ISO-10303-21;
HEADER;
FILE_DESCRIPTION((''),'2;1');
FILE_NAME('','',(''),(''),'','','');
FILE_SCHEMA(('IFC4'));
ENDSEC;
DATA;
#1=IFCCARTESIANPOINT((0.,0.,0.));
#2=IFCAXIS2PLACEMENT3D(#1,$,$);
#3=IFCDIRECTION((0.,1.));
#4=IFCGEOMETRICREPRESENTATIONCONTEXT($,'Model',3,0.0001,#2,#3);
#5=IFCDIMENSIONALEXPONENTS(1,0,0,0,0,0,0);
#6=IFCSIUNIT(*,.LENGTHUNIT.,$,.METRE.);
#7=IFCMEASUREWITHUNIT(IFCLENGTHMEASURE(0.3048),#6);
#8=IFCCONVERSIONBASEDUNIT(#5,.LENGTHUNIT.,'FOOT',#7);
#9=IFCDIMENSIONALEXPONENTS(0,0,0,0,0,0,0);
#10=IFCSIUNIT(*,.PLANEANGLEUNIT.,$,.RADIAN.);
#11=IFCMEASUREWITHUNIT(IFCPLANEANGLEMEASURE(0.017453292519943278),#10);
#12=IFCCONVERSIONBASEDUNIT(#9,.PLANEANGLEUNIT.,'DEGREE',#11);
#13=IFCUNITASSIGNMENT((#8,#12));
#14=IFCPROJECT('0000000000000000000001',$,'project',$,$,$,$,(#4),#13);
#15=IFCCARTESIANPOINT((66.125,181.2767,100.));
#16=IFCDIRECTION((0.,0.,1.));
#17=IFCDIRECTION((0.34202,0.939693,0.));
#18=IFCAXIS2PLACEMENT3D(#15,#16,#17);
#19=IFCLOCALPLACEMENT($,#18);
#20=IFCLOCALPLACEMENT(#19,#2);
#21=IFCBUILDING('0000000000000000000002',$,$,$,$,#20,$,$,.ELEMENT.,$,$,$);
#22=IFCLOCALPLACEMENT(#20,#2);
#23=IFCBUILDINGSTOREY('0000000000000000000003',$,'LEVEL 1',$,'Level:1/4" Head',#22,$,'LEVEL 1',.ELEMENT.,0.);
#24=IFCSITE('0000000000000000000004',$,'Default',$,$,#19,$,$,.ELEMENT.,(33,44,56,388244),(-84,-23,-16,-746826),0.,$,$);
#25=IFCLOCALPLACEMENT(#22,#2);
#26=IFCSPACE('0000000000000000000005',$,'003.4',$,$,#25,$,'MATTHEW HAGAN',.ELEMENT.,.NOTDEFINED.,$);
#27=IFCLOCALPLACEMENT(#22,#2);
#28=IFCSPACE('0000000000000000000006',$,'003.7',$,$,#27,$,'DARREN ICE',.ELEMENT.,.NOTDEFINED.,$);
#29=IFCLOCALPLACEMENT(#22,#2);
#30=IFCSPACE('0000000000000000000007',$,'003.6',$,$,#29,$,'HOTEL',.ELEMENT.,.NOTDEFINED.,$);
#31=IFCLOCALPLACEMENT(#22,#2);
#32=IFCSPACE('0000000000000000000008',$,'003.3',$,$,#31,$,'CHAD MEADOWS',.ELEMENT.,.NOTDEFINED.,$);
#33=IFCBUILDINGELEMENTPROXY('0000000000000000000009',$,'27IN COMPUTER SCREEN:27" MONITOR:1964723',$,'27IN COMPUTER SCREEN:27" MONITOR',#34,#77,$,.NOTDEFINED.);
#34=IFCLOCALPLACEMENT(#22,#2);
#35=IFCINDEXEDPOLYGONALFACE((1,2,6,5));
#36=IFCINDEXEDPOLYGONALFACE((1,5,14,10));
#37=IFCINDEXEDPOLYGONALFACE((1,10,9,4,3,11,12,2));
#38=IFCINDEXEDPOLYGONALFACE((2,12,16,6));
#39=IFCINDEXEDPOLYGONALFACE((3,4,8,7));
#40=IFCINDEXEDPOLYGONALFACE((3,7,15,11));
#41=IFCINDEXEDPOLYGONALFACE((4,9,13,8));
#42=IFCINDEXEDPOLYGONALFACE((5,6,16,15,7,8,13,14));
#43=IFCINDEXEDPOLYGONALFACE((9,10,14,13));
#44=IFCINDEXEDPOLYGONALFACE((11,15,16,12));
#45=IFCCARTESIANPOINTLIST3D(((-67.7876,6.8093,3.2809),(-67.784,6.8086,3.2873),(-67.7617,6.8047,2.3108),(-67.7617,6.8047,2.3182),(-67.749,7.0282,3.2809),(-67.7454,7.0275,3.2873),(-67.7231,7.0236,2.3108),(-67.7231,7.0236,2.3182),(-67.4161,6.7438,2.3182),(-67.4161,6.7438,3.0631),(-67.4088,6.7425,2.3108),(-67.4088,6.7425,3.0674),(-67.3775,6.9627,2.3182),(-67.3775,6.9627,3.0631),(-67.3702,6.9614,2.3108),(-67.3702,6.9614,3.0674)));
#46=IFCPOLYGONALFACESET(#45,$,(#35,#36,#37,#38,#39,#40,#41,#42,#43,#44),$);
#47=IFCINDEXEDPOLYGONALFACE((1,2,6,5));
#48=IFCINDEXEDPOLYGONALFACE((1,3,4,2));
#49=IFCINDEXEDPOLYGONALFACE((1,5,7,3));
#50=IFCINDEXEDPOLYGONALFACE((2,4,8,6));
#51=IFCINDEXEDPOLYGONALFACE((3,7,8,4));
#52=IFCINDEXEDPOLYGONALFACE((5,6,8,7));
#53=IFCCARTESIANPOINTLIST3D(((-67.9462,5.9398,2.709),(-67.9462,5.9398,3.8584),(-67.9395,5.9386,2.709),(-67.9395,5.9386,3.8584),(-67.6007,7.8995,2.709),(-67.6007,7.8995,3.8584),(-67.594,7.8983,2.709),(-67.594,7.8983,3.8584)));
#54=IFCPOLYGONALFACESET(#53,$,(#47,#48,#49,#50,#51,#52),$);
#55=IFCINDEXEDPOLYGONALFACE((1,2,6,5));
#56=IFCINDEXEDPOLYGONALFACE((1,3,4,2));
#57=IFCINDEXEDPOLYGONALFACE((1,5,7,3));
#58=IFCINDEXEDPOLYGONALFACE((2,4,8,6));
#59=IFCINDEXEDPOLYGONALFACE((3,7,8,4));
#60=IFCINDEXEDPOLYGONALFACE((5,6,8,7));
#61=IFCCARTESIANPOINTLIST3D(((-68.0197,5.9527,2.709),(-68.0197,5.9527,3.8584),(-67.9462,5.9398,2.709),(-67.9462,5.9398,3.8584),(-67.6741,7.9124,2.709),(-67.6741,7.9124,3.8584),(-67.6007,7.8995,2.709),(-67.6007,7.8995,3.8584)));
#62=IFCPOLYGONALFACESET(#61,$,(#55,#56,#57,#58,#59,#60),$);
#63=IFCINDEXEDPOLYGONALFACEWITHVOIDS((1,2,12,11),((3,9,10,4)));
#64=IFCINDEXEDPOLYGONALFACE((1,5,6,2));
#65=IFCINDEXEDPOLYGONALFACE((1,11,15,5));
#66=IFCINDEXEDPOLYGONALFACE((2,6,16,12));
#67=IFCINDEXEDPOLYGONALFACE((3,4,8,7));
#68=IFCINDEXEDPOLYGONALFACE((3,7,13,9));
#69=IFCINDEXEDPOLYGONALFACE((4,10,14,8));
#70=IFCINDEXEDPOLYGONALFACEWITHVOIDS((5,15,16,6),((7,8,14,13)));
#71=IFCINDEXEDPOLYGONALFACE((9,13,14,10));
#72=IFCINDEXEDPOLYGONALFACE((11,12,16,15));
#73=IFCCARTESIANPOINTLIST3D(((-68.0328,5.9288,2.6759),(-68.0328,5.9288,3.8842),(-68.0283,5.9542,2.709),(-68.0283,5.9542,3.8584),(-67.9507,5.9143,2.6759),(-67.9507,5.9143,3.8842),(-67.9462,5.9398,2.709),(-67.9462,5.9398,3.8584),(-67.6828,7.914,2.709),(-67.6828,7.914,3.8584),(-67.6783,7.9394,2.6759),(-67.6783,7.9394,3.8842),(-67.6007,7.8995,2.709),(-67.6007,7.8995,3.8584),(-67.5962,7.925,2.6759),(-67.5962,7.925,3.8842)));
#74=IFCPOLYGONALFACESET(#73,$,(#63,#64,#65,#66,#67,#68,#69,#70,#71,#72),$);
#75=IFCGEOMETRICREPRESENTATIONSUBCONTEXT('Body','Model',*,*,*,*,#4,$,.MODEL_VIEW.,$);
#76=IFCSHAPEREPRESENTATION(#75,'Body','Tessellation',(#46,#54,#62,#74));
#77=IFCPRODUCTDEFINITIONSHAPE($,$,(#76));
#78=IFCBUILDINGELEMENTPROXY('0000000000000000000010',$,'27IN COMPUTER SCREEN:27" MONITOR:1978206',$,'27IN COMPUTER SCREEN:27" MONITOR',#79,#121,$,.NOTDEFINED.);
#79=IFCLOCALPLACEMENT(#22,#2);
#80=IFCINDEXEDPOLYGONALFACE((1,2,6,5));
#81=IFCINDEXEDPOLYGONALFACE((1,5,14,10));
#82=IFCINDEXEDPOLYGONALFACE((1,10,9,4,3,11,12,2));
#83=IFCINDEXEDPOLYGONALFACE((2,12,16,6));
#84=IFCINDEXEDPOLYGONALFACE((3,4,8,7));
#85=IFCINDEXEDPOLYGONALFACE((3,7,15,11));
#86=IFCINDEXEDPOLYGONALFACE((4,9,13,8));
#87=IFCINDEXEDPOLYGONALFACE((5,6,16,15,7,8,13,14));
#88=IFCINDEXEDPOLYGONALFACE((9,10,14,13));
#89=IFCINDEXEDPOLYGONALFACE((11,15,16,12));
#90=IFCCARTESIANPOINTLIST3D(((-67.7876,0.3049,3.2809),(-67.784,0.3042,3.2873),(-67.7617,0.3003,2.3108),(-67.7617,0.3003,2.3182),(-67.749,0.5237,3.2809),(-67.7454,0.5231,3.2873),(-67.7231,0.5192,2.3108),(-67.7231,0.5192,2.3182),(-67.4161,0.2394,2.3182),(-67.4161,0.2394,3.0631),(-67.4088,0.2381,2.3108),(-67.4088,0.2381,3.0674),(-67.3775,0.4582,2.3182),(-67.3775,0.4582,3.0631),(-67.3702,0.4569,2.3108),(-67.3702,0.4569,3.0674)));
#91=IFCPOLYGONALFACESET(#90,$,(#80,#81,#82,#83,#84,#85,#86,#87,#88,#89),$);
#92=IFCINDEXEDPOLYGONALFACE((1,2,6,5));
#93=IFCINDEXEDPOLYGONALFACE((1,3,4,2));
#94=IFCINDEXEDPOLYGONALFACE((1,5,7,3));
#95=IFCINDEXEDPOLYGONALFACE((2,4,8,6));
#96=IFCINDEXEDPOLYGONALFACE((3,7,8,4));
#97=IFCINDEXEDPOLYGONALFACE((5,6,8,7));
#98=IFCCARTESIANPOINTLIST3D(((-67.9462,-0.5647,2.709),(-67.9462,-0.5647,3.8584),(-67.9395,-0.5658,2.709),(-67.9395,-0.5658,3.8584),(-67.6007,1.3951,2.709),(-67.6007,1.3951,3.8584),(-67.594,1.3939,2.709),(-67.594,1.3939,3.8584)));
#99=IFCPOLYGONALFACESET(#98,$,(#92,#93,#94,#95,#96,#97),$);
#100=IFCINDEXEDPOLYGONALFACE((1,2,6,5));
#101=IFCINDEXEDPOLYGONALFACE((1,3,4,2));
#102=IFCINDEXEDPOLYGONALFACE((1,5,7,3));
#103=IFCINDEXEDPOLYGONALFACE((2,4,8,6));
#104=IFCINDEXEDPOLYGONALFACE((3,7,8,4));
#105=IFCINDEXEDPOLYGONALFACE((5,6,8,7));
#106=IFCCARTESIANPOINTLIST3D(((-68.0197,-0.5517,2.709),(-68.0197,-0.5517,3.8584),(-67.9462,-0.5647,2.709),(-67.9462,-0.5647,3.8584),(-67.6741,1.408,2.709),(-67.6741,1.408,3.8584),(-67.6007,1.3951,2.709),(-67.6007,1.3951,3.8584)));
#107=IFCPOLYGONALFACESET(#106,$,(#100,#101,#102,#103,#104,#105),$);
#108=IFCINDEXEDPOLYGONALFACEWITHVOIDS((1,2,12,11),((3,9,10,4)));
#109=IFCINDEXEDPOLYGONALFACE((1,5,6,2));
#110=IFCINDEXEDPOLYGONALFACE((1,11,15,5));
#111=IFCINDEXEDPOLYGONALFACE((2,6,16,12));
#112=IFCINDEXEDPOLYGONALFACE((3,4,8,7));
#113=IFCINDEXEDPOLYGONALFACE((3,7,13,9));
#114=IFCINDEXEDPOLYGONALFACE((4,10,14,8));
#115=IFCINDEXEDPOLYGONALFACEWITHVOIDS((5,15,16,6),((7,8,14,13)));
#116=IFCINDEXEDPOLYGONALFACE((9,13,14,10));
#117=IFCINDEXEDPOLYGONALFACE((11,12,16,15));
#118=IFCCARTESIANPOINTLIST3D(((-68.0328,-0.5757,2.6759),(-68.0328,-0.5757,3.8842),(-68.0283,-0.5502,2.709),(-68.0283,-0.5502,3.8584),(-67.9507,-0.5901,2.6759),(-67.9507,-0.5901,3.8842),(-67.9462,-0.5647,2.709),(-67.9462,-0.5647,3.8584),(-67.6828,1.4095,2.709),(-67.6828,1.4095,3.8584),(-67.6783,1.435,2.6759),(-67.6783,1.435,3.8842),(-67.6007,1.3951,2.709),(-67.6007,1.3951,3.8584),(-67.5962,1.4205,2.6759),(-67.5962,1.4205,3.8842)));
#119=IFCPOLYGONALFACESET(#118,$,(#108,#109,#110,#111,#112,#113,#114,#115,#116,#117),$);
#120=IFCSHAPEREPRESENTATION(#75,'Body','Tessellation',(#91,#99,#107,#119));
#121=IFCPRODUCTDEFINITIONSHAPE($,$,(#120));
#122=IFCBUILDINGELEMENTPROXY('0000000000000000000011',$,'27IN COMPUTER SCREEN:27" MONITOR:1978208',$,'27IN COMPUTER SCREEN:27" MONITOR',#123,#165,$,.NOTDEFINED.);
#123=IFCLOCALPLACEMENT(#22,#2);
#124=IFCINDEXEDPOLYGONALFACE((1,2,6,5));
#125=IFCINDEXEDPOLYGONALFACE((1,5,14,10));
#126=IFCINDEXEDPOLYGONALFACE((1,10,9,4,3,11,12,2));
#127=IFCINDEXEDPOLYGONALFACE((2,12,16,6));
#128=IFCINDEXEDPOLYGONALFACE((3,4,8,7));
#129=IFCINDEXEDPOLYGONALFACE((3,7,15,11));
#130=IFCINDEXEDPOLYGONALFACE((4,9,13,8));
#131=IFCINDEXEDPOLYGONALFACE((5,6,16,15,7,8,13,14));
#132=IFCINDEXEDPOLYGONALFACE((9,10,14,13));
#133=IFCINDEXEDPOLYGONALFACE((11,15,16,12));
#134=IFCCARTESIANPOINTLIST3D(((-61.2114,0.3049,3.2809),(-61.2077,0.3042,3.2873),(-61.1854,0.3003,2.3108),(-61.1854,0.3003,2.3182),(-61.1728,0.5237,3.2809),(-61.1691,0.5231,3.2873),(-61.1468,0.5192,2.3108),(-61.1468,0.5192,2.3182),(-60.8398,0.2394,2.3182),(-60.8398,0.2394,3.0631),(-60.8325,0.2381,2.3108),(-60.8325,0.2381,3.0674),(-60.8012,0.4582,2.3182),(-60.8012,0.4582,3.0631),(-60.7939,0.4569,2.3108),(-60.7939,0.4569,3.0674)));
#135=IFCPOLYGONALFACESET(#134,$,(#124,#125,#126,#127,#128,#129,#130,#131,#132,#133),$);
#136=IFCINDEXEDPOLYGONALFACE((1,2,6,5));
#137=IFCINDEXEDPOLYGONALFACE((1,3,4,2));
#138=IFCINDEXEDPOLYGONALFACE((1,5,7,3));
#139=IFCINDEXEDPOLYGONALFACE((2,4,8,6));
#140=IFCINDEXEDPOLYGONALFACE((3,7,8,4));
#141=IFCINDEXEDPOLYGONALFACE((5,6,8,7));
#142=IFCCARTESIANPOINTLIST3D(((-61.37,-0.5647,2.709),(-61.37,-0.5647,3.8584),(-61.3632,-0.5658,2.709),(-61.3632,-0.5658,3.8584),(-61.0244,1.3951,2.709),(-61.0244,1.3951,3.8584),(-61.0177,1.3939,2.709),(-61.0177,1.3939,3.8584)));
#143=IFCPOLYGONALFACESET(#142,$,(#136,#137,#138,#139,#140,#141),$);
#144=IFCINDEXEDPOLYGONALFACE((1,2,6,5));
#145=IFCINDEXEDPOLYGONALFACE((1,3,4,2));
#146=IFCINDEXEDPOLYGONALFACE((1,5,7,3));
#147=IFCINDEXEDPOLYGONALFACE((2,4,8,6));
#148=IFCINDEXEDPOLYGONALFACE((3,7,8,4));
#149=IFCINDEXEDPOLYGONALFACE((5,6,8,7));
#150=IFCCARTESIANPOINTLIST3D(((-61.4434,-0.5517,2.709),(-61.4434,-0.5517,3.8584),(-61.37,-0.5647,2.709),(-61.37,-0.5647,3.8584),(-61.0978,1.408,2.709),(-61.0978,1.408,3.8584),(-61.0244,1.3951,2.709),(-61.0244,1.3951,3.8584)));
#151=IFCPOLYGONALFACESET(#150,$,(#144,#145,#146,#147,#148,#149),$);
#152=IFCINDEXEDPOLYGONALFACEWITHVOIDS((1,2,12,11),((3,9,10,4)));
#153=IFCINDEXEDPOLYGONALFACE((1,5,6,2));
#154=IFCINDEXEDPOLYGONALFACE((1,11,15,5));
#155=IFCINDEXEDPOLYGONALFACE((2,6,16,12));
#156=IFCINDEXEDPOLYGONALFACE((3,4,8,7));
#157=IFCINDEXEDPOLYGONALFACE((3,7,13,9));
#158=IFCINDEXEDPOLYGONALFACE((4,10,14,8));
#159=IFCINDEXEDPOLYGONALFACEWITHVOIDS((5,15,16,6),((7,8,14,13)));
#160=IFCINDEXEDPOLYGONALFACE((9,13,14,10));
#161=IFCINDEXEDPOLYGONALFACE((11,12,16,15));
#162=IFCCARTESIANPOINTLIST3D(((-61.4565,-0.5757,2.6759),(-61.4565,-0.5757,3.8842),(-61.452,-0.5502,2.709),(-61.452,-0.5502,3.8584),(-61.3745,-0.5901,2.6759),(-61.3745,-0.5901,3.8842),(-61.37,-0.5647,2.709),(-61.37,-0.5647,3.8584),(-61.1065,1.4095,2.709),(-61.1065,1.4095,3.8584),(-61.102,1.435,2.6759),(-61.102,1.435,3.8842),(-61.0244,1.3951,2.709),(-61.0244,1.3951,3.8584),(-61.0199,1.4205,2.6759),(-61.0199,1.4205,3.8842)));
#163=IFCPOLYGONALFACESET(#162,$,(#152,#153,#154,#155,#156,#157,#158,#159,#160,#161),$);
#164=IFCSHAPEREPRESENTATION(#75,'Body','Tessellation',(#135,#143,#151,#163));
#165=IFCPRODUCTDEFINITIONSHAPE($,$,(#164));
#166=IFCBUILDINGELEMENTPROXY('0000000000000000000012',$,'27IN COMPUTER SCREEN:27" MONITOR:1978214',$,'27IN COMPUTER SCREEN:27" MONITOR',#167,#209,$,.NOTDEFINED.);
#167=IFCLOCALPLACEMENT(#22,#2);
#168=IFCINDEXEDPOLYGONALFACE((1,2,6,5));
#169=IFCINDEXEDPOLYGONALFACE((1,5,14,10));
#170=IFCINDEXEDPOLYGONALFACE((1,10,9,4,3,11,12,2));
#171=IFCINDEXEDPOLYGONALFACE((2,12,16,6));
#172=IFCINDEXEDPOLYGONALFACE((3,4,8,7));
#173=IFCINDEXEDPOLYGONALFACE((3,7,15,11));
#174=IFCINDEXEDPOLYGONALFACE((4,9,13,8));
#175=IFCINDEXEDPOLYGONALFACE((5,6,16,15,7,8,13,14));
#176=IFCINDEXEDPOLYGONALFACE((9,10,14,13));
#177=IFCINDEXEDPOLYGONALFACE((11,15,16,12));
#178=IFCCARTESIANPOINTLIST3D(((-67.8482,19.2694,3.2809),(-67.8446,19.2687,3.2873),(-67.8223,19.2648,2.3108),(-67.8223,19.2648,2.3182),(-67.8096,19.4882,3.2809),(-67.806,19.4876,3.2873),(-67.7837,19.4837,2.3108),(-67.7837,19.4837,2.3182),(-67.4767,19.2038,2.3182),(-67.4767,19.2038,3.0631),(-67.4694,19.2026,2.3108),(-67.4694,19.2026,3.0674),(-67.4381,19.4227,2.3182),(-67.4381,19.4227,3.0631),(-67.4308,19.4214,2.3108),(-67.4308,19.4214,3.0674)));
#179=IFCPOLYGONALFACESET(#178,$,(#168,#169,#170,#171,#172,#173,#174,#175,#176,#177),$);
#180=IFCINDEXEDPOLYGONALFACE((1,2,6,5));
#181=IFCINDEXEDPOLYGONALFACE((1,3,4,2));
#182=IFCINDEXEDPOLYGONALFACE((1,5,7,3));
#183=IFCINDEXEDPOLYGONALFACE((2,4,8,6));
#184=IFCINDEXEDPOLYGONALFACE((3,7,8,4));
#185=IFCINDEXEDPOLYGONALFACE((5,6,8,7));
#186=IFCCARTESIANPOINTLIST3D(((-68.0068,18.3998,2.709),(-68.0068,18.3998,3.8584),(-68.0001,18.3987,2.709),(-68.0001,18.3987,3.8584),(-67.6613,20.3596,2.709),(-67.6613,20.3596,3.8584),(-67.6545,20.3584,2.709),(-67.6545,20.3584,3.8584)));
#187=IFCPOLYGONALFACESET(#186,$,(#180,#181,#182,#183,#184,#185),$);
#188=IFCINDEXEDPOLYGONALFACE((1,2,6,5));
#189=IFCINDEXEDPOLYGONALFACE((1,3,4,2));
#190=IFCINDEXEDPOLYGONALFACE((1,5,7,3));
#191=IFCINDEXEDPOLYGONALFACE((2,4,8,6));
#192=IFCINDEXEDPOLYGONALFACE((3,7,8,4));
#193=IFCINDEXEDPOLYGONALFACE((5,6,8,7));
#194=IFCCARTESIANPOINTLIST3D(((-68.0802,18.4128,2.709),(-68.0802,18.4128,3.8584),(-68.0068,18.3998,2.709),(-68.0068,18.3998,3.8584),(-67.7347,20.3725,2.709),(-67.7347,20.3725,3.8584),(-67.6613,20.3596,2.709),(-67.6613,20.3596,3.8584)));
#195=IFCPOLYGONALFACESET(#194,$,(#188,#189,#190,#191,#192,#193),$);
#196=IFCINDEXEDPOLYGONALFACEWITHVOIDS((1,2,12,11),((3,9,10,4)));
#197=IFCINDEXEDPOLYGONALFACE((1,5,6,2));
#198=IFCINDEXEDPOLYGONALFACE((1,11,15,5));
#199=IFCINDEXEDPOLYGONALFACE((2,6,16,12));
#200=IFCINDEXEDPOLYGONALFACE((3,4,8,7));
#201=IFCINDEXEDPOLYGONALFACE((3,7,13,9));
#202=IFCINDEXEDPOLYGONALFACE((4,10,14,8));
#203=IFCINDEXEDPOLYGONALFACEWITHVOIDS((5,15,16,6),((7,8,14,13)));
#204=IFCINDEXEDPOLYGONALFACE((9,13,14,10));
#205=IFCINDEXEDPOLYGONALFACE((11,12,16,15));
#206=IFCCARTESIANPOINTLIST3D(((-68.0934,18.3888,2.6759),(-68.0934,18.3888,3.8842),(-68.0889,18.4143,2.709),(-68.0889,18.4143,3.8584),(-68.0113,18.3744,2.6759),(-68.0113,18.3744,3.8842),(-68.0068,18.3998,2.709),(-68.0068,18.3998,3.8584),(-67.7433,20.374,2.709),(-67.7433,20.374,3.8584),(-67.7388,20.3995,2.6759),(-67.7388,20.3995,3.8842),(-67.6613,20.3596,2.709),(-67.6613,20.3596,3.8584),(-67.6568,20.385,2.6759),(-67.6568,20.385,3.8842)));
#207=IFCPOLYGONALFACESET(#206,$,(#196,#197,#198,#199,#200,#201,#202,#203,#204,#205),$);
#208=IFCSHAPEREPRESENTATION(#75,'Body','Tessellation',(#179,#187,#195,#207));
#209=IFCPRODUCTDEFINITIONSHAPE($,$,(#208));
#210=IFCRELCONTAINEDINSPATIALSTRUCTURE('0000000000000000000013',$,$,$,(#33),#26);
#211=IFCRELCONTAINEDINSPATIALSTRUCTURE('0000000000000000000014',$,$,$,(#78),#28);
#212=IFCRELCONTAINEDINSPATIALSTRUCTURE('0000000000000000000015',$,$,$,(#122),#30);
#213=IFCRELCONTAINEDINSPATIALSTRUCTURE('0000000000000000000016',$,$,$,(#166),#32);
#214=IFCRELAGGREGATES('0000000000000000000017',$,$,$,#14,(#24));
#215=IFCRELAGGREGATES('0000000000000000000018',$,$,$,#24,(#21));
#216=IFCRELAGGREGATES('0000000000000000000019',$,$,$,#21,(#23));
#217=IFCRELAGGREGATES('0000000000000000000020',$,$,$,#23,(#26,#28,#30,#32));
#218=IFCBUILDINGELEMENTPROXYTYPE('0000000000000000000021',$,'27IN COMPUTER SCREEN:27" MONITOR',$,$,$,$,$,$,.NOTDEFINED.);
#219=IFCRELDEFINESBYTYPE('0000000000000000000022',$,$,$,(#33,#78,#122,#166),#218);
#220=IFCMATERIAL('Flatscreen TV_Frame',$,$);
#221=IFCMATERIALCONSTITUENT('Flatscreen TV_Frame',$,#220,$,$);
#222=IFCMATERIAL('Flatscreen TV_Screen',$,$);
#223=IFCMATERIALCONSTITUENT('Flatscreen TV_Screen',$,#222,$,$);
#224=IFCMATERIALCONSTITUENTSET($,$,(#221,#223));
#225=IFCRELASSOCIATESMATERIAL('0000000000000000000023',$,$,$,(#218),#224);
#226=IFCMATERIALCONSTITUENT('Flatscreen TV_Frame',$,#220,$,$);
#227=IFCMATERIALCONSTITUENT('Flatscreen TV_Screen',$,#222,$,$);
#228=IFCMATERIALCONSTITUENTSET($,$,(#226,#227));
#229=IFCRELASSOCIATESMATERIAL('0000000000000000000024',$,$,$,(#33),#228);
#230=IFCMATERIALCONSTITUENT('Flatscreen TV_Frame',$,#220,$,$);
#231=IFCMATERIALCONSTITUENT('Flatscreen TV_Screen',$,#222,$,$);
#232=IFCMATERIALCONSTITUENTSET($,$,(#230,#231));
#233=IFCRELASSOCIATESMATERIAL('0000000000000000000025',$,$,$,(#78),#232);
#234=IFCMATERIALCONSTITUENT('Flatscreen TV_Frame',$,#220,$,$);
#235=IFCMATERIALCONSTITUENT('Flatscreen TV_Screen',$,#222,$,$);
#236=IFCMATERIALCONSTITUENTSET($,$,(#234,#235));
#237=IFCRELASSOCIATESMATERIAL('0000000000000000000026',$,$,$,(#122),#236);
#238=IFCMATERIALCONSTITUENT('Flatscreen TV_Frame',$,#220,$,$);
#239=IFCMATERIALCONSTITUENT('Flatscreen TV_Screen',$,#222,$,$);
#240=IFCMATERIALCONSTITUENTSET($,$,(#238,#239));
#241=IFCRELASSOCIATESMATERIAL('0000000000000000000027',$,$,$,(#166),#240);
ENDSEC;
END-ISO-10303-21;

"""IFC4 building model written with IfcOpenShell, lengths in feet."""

from ifc_helpers import new_model, entity, si_unit, converted_unit, direction, frame, frame_2d, origin, origin_2d_with_axis, place, context, subcontext, project, spatial, polyline, rectangle, outline, extrude, source, transform, mapped, material, constituent, constituent_set, type_object, type_shapes, element, save


model = new_model("IFC4")

# Units and contexts
model_context = context("Model", 3, precision=0.0001, world=origin(), true_north=direction((0.0, 1.0)))
body_context = subcontext(model_context, "Body", "Model", "MODEL_VIEW")
ifc_project = project(units=[converted_unit("LENGTHUNIT", "FOOT", entity("IfcLengthMeasure", 0.3048), si_unit("LENGTHUNIT", "METRE"), dimensions=[1, 0, 0, 0, 0, 0, 0]), converted_unit("PLANEANGLEUNIT", "DEGREE", entity("IfcPlaneAngleMeasure", 0.017453292519943278), si_unit("PLANEANGLEUNIT", "RADIAN"), dimensions=[0, 0, 0, 0, 0, 0, 0])], contexts=[model_context])

# Site, building, storey
site_placement = place(None, frame((66.125, 181.2767, 100.0), z_axis=(0.0, 0.0, 1.0), x_axis=(0.34202, 0.939693, 0.0)))
site = spatial("IfcSite", under=ifc_project, at=site_placement, Name="Default", CompositionType="ELEMENT", RefLatitude=(33, 44, 56, 388244), RefLongitude=(-84, -23, -16, -746826), RefElevation=0.0)
building_placement = place(site_placement, origin())
building = spatial("IfcBuilding", under=site, at=building_placement, CompositionType="ELEMENT")
storey_placement = place(building_placement, origin())
storey = spatial("IfcBuildingStorey", under=building, at=storey_placement, Name="LEVEL 1", ObjectType="Level:1/4\" Head", LongName="LEVEL 1", CompositionType="ELEMENT", Elevation=0.0)

# Shared definitions
space_1_placement = place(storey_placement, origin())
space_1 = spatial("IfcSpace", under=storey, at=space_1_placement, Name="003.4", LongName="MATTHEW HAGAN", CompositionType="ELEMENT", PredefinedType="NOTDEFINED")

# Shared definitions
space_2_placement = place(storey_placement, origin())
space_2 = spatial("IfcSpace", under=storey, at=space_2_placement, Name="003.7", LongName="DARREN ICE", CompositionType="ELEMENT", PredefinedType="NOTDEFINED")

# Shared definitions
space_3_placement = place(storey_placement, origin())
space_3 = spatial("IfcSpace", under=storey, at=space_3_placement, Name="003.6", LongName="HOTEL", CompositionType="ELEMENT", PredefinedType="NOTDEFINED")

# Building element proxies
ifc_material_1 = material(Name="Flatscreen TV_Frame")
ifc_constituent_1 = constituent(ifc_material_1, Name="Flatscreen TV_Frame")
ifc_material_2 = material(Name="Flatscreen TV_Screen")
ifc_constituent_2 = constituent(ifc_material_2, Name="Flatscreen TV_Screen")
ifc_constituent_set_1 = constituent_set(constituents=[ifc_constituent_1, ifc_constituent_2])
ifc_constituent_3 = constituent(ifc_material_1, Name="Flatscreen TV_Frame")
ifc_constituent_4 = constituent(ifc_material_2, Name="Flatscreen TV_Screen")
ifc_constituent_set_2 = constituent_set(constituents=[ifc_constituent_3, ifc_constituent_4])
building_element_proxy_type_1 = type_object("IfcBuildingElementProxyType", Name="27IN COMPUTER SCREEN:27\" MONITOR", PredefinedType="NOTDEFINED", material=ifc_constituent_set_2)
shared_shape_1 = source(origin(), body_context, "Body", "SweptSolid", [
    extrude(outline(polyline([(-0.4392, -0.3657), (-0.4392, -0.3731), (0.0007, -0.3731), (0.379, 0.2821), (0.0686, 0.4613), (0.0649, 0.4548), (0.3688, 0.2794), (-0.0036, -0.3657), (-0.4392, -0.3657)])), frame((-0.1111, -0.0264, 0.0687), z_axis=(-1.0, 0.0, 0.0), x_axis=(0.0, 0.866025, -0.5)), (0.0, 0.0, -1.0), 0.2222),
    extrude(rectangle(XDim=0.0068, YDim=1.9899, at=origin_2d_with_axis()), frame((0.0, -0.2257, 0.0331), z_axis=(0.0, 0.0, 1.0), x_axis=(0.0, 1.0, 0.0)), (0.0, 0.0, 1.0), 1.1493),
    extrude(rectangle(XDim=0.0746, YDim=1.9899, at=frame_2d((0.0, 0.0), x_axis=(1.0, 0.0))), frame((0.0, -0.2664, 0.0331), z_axis=(0.0, 0.0, 1.0), x_axis=(0.0, 1.0, 0.0)), (0.0, 0.0, 1.0), 1.1493),
    extrude(outline(polyline([(-0.6042, -1.0208), (0.6042, -1.0208), (0.6042, 1.0208), (-0.6042, 1.0208), (-0.6042, -1.0208)]), holes=[polyline([(-0.5783, -0.995), (-0.5783, 0.995), (0.571, 0.995), (0.571, -0.995), (-0.5783, -0.995)])]), frame((0.0, -0.3125, 0.6042), z_axis=(0.0, 1.0, 0.0), x_axis=(0.0, 0.0, -1.0)), (0.0, 0.0, 1.0), 0.0833),
])
type_shapes(building_element_proxy_type_1, [shared_shape_1])
proxy_1_placement = place(space_1_placement, frame((-67.5478, 6.8798, 2.6759), z_axis=(0.0, 0.0, 1.0), x_axis=(-0.173648, -0.984808, 0.0)))
element("IfcBuildingElementProxy", 1, at=proxy_1_placement, inside=space_1, type_object=building_element_proxy_type_1, material=ifc_constituent_set_1, Name="27IN COMPUTER SCREEN:27\" MONITOR:1964723", ObjectType="27IN COMPUTER SCREEN:27\" MONITOR", PredefinedType="NOTDEFINED", context=body_context, shape_type="MappedRepresentation", body=[
    mapped(shared_shape_1, transform((0.0, 0.0, 0.0), scale=1.0)),
])
ifc_constituent_5 = constituent(ifc_material_1, Name="Flatscreen TV_Frame")
ifc_constituent_6 = constituent(ifc_material_2, Name="Flatscreen TV_Screen")
ifc_constituent_set_3 = constituent_set(constituents=[ifc_constituent_5, ifc_constituent_6])
proxy_2_placement = place(space_2_placement, frame((-67.5478, 0.3754, 2.6759), z_axis=(0.0, 0.0, 1.0), x_axis=(-0.173648, -0.984808, 0.0)))
element("IfcBuildingElementProxy", 2, at=proxy_2_placement, inside=space_2, type_object=building_element_proxy_type_1, material=ifc_constituent_set_3, Name="27IN COMPUTER SCREEN:27\" MONITOR:1978206", ObjectType="27IN COMPUTER SCREEN:27\" MONITOR", PredefinedType="NOTDEFINED", context=body_context, shape_type="MappedRepresentation", body=[
    mapped(shared_shape_1, transform((0.0, 0.0, 0.0), scale=1.0)),
])
ifc_constituent_7 = constituent(ifc_material_1, Name="Flatscreen TV_Frame")
ifc_constituent_8 = constituent(ifc_material_2, Name="Flatscreen TV_Screen")
ifc_constituent_set_4 = constituent_set(constituents=[ifc_constituent_7, ifc_constituent_8])
proxy_3_placement = place(space_3_placement, frame((-60.9715, 0.3754, 2.6759), z_axis=(0.0, 0.0, 1.0), x_axis=(-0.173648, -0.984808, 0.0)))
element("IfcBuildingElementProxy", 3, at=proxy_3_placement, inside=space_3, type_object=building_element_proxy_type_1, material=ifc_constituent_set_4, Name="27IN COMPUTER SCREEN:27\" MONITOR:1978208", ObjectType="27IN COMPUTER SCREEN:27\" MONITOR", PredefinedType="NOTDEFINED", context=body_context, shape_type="MappedRepresentation", body=[
    mapped(shared_shape_1, transform((0.0, 0.0, 0.0), scale=1.0)),
])

# Shared definitions
space_4_placement = place(storey_placement, origin())
space_4 = spatial("IfcSpace", under=storey, at=space_4_placement, Name="003.3", LongName="CHAD MEADOWS", CompositionType="ELEMENT", PredefinedType="NOTDEFINED")

# Building element proxy
ifc_constituent_9 = constituent(ifc_material_1, Name="Flatscreen TV_Frame")
ifc_constituent_10 = constituent(ifc_material_2, Name="Flatscreen TV_Screen")
ifc_constituent_set_5 = constituent_set(constituents=[ifc_constituent_9, ifc_constituent_10])
proxy_4_placement = place(space_4_placement, frame((-67.6083, 19.3399, 2.6759), z_axis=(0.0, 0.0, 1.0), x_axis=(-0.173648, -0.984808, 0.0)))
element("IfcBuildingElementProxy", 4, at=proxy_4_placement, inside=space_4, type_object=building_element_proxy_type_1, material=ifc_constituent_set_5, Name="27IN COMPUTER SCREEN:27\" MONITOR:1978214", ObjectType="27IN COMPUTER SCREEN:27\" MONITOR", PredefinedType="NOTDEFINED", context=body_context, shape_type="MappedRepresentation", body=[
    mapped(shared_shape_1, transform((0.0, 0.0, 0.0), scale=1.0)),
])

save(model, "model.ifc")
